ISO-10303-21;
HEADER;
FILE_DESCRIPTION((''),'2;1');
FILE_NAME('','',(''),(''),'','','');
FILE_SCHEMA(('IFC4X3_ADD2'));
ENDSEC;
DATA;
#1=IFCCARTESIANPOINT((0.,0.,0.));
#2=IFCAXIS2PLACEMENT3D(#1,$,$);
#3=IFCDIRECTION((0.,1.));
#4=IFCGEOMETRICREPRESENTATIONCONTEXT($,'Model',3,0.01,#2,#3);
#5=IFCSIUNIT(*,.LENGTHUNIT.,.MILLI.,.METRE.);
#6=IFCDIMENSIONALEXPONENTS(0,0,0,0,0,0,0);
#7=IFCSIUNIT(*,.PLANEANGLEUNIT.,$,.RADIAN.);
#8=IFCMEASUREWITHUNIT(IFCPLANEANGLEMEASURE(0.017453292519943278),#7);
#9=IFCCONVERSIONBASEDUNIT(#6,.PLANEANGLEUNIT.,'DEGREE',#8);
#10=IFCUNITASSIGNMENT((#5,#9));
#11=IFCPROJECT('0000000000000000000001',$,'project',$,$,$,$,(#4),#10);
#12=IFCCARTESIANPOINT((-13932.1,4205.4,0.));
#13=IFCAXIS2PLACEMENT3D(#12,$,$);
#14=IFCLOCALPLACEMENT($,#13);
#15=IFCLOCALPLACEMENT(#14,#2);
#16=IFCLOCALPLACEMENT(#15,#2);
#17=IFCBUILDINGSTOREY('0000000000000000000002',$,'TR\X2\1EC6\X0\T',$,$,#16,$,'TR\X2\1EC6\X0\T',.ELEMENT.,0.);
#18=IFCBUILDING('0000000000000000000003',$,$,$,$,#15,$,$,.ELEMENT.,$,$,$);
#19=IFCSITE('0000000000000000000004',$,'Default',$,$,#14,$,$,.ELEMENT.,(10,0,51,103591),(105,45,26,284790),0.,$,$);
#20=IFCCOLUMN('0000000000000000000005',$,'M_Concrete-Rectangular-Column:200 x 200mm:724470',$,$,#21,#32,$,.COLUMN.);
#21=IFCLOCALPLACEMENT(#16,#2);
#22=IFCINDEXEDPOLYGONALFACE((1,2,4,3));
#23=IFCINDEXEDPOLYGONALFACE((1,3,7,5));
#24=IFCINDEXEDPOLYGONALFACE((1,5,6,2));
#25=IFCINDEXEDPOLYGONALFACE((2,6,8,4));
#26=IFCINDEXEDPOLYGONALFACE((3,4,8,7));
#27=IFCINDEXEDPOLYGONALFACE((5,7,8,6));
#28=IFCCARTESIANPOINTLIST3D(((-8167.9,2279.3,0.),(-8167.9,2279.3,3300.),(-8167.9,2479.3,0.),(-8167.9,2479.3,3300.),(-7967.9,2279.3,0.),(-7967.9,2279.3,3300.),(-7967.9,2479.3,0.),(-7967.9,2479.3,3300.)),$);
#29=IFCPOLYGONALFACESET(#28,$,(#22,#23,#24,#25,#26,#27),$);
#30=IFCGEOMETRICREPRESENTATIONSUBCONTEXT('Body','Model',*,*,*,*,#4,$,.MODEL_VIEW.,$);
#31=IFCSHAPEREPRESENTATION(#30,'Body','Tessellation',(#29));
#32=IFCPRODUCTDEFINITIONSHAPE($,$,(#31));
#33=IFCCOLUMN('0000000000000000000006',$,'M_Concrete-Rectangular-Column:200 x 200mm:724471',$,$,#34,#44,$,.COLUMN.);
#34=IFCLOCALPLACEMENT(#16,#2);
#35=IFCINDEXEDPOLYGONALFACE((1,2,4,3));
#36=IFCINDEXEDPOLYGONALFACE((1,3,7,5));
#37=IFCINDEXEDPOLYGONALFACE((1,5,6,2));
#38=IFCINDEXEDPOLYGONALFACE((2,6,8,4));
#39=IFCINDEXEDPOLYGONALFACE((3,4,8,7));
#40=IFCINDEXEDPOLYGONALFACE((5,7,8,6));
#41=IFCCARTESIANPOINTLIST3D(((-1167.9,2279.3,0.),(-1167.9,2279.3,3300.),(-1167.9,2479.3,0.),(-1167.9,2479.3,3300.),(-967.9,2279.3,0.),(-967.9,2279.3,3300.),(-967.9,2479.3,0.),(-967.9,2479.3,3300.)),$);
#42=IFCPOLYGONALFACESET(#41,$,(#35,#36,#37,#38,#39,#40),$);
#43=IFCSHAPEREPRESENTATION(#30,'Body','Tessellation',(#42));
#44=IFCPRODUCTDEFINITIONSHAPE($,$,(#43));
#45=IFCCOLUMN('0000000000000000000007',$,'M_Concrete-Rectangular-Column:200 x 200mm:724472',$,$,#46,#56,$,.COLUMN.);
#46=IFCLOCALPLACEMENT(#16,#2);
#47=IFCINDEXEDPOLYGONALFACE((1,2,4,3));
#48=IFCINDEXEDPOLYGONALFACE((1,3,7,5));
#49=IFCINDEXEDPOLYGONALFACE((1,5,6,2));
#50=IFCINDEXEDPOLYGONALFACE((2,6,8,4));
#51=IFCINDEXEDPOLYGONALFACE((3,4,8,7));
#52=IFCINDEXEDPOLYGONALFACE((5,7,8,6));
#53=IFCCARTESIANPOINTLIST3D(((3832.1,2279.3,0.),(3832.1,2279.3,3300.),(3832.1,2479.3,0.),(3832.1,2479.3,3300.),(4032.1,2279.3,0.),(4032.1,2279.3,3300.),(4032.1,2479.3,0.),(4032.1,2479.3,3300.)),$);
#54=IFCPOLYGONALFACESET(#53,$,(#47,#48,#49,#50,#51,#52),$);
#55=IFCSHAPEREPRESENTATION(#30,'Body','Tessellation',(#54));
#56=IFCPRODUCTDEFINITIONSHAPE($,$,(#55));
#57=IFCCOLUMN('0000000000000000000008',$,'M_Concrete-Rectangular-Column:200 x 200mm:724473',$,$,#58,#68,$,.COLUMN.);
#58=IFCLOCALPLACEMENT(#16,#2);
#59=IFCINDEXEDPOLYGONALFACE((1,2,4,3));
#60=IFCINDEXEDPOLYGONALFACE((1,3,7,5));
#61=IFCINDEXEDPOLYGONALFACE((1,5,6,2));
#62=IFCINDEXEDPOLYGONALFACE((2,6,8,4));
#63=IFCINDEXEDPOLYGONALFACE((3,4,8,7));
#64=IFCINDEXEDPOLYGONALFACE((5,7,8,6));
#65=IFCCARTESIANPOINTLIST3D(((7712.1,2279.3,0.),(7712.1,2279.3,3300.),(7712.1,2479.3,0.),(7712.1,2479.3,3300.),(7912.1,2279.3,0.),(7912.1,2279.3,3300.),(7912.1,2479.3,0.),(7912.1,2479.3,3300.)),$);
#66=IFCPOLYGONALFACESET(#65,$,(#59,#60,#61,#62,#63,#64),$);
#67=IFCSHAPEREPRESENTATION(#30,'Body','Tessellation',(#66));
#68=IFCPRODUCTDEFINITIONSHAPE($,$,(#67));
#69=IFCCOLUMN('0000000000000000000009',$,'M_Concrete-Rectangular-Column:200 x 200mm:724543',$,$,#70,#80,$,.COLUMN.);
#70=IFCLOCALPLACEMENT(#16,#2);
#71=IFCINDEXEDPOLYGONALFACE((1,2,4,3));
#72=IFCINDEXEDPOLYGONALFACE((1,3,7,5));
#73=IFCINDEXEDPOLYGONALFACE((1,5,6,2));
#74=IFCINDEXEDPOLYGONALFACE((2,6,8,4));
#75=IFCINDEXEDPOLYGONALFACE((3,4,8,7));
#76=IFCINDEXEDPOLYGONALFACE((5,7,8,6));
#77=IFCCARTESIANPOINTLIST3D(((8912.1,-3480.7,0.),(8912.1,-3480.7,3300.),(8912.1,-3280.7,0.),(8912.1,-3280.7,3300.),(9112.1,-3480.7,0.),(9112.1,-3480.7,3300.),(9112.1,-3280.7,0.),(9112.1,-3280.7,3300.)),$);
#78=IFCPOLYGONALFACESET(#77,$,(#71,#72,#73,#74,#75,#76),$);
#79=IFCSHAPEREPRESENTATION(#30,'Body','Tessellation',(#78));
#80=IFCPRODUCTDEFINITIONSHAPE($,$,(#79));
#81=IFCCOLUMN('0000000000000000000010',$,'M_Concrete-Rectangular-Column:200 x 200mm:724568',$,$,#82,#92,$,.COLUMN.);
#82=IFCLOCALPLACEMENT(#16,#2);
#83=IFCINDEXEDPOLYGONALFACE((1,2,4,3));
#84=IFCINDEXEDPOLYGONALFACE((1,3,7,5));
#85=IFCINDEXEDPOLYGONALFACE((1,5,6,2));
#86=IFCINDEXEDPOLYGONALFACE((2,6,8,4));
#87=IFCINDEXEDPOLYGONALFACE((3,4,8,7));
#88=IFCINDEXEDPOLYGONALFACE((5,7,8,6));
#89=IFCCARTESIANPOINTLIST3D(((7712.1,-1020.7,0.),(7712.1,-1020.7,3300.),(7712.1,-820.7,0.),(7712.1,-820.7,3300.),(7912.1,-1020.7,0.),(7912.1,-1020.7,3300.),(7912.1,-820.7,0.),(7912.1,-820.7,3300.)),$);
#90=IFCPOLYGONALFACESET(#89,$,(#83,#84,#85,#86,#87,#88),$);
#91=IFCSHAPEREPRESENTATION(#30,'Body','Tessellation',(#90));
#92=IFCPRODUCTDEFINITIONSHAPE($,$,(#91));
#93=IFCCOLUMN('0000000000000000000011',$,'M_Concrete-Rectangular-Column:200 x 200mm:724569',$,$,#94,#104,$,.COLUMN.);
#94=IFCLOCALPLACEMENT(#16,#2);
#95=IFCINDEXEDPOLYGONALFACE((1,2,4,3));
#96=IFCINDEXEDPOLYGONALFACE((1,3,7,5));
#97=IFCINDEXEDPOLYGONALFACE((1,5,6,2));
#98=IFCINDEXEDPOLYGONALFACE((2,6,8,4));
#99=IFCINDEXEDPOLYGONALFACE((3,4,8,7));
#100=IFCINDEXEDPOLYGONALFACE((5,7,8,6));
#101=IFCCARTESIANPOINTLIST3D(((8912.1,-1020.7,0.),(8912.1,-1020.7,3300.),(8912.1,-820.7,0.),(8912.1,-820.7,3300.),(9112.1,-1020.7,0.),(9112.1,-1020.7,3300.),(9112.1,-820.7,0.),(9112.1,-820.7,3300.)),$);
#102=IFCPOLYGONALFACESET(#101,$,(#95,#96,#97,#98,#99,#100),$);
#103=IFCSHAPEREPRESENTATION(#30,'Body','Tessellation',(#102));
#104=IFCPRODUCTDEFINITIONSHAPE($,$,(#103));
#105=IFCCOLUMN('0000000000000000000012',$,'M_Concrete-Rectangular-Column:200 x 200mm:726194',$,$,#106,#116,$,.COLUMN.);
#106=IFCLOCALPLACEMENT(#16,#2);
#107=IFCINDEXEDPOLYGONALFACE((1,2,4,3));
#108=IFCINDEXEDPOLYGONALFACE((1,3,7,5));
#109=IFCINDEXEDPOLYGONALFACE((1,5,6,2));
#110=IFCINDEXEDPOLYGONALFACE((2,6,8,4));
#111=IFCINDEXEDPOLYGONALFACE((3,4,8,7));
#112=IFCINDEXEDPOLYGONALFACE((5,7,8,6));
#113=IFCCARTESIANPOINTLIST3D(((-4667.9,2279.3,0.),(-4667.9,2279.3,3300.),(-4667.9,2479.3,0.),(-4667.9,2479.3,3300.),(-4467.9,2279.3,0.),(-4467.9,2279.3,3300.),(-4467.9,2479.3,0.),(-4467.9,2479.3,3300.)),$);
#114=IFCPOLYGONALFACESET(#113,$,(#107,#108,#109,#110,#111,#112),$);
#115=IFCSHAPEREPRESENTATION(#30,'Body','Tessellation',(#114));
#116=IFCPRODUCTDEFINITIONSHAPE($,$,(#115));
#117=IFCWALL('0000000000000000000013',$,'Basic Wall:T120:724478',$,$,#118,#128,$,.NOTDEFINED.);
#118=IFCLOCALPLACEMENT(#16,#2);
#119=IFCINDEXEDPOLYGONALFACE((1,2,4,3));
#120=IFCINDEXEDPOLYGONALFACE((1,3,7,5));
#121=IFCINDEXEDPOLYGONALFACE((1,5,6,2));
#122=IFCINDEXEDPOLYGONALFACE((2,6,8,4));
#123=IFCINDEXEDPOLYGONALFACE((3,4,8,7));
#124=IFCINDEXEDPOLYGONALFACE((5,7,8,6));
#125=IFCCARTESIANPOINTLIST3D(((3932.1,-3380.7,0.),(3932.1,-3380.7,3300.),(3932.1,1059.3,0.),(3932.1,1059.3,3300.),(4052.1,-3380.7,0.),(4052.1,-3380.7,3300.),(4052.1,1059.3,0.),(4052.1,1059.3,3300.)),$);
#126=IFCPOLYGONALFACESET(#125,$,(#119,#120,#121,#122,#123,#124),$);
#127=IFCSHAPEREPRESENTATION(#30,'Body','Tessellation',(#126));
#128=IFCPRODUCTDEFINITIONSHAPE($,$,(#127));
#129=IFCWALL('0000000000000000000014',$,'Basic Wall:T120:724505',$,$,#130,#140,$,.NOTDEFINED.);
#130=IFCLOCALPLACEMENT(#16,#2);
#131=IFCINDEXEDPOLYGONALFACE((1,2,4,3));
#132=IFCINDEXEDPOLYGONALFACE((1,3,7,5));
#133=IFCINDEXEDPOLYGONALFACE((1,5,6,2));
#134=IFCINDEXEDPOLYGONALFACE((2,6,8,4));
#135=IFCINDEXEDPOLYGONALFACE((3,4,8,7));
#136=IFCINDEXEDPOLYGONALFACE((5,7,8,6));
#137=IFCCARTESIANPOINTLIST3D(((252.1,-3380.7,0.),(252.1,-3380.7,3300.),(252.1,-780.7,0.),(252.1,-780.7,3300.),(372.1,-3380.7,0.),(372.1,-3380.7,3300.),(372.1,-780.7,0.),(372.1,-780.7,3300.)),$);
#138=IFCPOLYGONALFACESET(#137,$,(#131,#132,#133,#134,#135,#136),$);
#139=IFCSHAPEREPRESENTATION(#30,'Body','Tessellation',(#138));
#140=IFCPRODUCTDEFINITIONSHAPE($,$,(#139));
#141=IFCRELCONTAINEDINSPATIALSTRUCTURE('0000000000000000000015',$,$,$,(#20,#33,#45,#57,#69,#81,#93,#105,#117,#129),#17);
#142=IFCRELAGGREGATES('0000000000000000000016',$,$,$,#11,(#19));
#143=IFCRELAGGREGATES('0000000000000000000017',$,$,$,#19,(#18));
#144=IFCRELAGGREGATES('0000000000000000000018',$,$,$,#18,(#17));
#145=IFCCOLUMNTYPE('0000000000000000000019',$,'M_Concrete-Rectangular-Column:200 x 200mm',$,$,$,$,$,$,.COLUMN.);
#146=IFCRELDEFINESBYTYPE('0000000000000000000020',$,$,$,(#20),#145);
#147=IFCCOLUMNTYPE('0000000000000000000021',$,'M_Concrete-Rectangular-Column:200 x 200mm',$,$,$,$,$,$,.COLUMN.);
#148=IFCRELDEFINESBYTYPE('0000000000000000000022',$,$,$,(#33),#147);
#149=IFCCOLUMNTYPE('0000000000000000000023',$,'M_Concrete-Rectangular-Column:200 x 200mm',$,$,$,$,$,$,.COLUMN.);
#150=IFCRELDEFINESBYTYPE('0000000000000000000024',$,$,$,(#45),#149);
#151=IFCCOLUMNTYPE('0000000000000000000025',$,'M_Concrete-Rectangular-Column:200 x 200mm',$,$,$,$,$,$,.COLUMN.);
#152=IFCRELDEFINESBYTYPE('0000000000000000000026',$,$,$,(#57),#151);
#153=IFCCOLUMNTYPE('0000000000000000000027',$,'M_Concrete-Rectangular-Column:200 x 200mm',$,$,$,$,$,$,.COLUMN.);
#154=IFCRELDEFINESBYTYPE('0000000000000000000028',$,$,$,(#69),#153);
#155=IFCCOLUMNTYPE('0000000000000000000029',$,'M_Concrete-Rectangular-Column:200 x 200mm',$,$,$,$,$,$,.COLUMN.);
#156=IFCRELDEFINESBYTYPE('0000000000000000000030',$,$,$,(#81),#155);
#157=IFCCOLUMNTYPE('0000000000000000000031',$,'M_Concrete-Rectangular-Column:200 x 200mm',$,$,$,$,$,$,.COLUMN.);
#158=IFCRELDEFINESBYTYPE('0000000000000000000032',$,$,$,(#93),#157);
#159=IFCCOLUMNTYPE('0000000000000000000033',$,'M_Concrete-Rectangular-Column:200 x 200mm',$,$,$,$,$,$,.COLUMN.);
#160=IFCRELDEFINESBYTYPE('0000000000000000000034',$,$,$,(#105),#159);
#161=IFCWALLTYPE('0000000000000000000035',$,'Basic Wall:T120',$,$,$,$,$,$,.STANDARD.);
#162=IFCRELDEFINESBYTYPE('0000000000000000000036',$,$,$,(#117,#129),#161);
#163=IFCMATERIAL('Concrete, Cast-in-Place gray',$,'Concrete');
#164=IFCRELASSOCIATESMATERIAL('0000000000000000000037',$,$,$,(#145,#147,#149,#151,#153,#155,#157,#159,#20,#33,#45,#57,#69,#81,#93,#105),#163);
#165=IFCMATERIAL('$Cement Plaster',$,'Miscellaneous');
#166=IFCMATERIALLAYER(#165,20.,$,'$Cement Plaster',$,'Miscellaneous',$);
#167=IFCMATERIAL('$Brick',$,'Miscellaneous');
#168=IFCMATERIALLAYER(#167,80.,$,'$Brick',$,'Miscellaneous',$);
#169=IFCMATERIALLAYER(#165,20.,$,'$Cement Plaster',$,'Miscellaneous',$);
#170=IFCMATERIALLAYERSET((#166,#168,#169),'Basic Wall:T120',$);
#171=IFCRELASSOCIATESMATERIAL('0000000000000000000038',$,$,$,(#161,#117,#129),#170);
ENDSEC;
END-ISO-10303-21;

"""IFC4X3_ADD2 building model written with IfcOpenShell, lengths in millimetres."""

from ifc_helpers import new_model, entity, si_unit, converted_unit, direction, frame, frame_2d, origin, origin_2d_with_axis, place, context, subcontext, project, spatial, rectangle, extrude, source, transform, mapped, material, layer, layer_set, material_profile, profile_set, profile_usage, type_object, type_shapes, element, save


model = new_model("IFC4X3_ADD2")

# Units and contexts
model_context = context("Model", 3, precision=0.01, world=origin(), true_north=direction((0.0, 1.0)))
body_context = subcontext(model_context, "Body", "Model", "MODEL_VIEW")
ifc_project = project(units=[si_unit("LENGTHUNIT", "METRE", prefix="MILLI"), converted_unit("PLANEANGLEUNIT", "DEGREE", entity("IfcPlaneAngleMeasure", 0.017453292519943278), si_unit("PLANEANGLEUNIT", "RADIAN"), dimensions=[0, 0, 0, 0, 0, 0, 0])], contexts=[model_context])

# Site, building, storey
site_placement = place(None, frame((-13932.1, 4205.4, 0.0)))
site = spatial("IfcSite", under=ifc_project, at=site_placement, Name="Default", CompositionType="ELEMENT", RefLatitude=(10, 0, 51, 103591), RefLongitude=(105, 45, 26, 284790), RefElevation=0.0)
building_placement = place(site_placement, origin())
building = spatial("IfcBuilding", under=site, at=building_placement, CompositionType="ELEMENT")
storey_placement = place(building_placement, origin())
storey = spatial("IfcBuildingStorey", under=building, at=storey_placement, Name="TRỆT", LongName="TRỆT", CompositionType="ELEMENT", Elevation=0.0)

# Columns
ifc_material_1 = material(Name="Concrete, Cast-in-Place gray", Category="Concrete")
ifc_material_profile = material_profile(ifc_material_1, rectangle(XDim=200.0, YDim=200.0, at=frame_2d((0.0, 14.3), x_axis=(1.0, 0.0))), Name="200 x 200mm")
ifc_profile_set = profile_set([ifc_material_profile], Name="200 x 200mm")
ifc_profile_usage = profile_usage(ifc_profile_set)
column_type_1 = type_object("IfcColumnType", Name="M_Concrete-Rectangular-Column:200 x 200mm", PredefinedType="COLUMN", material=ifc_profile_set)
shared_shape_1 = source(origin(), body_context, "Body", "SweptSolid", [
    extrude(rectangle(XDim=200.0, YDim=200.0, at=frame_2d((0.0, 0.0), x_axis=(1.0, 0.0))), frame((-8067.9, 2379.3, 0.0), z_axis=(0.0, 0.0, 1.0), x_axis=(-1.0, 0.0, 0.0)), (0.0, 0.0, 1.0), 3300.0),
])
type_shapes(column_type_1, [shared_shape_1])
column_1_placement = place(storey_placement, origin())
element("IfcColumn", 1, at=column_1_placement, inside=storey, type_object=column_type_1, material=ifc_profile_usage, Name="M_Concrete-Rectangular-Column:200 x 200mm:724470", PredefinedType="COLUMN", context=body_context, shape_type="MappedRepresentation", body=[
    mapped(shared_shape_1, transform((0.0, 0.0, 0.0), scale=1.0)),
])
column_type_2 = type_object("IfcColumnType", Name="M_Concrete-Rectangular-Column:200 x 200mm", PredefinedType="COLUMN", material=ifc_profile_set)
shared_shape_2 = source(origin(), body_context, "Body", "SweptSolid", [
    extrude(rectangle(XDim=200.0, YDim=200.0, at=frame_2d((0.0, 0.0), x_axis=(1.0, 0.0))), frame((-1067.9, 2379.3, 0.0), z_axis=(0.0, 0.0, 1.0), x_axis=(-1.0, 0.0, 0.0)), (0.0, 0.0, 1.0), 3300.0),
])
type_shapes(column_type_2, [shared_shape_2])
column_2_placement = place(storey_placement, origin())
element("IfcColumn", 2, at=column_2_placement, inside=storey, type_object=column_type_2, material=ifc_profile_usage, Name="M_Concrete-Rectangular-Column:200 x 200mm:724471", PredefinedType="COLUMN", context=body_context, shape_type="MappedRepresentation", body=[
    mapped(shared_shape_2, transform((0.0, 0.0, 0.0), scale=1.0)),
])
column_type_3 = type_object("IfcColumnType", Name="M_Concrete-Rectangular-Column:200 x 200mm", PredefinedType="COLUMN", material=ifc_profile_set)
shared_shape_3 = source(origin(), body_context, "Body", "SweptSolid", [
    extrude(rectangle(XDim=200.0, YDim=200.0, at=frame_2d((0.0, 0.0), x_axis=(1.0, 0.0))), frame((3932.1, 2379.3, 0.0), z_axis=(0.0, 0.0, 1.0), x_axis=(-1.0, 0.0, 0.0)), (0.0, 0.0, 1.0), 3300.0),
])
type_shapes(column_type_3, [shared_shape_3])
column_3_placement = place(storey_placement, origin())
element("IfcColumn", 3, at=column_3_placement, inside=storey, type_object=column_type_3, material=ifc_profile_usage, Name="M_Concrete-Rectangular-Column:200 x 200mm:724472", PredefinedType="COLUMN", context=body_context, shape_type="MappedRepresentation", body=[
    mapped(shared_shape_3, transform((0.0, 0.0, 0.0), scale=1.0)),
])
column_type_4 = type_object("IfcColumnType", Name="M_Concrete-Rectangular-Column:200 x 200mm", PredefinedType="COLUMN", material=ifc_profile_set)
shared_shape_4 = source(origin(), body_context, "Body", "SweptSolid", [
    extrude(rectangle(XDim=200.0, YDim=200.0, at=frame_2d((0.0, 0.0), x_axis=(1.0, 0.0))), frame((7812.1, 2379.3, 0.0), z_axis=(0.0, 0.0, 1.0), x_axis=(-1.0, 0.0, 0.0)), (0.0, 0.0, 1.0), 3300.0),
])
type_shapes(column_type_4, [shared_shape_4])
column_4_placement = place(storey_placement, origin())
element("IfcColumn", 4, at=column_4_placement, inside=storey, type_object=column_type_4, material=ifc_profile_usage, Name="M_Concrete-Rectangular-Column:200 x 200mm:724473", PredefinedType="COLUMN", context=body_context, shape_type="MappedRepresentation", body=[
    mapped(shared_shape_4, transform((0.0, 0.0, 0.0), scale=1.0)),
])
column_type_5 = type_object("IfcColumnType", Name="M_Concrete-Rectangular-Column:200 x 200mm", PredefinedType="COLUMN", material=ifc_profile_set)
shared_shape_5 = source(origin(), body_context, "Body", "SweptSolid", [
    extrude(rectangle(XDim=200.0, YDim=200.0, at=frame_2d((0.0, 0.0), x_axis=(1.0, 0.0))), frame((9012.1, -3380.7, 0.0), z_axis=(0.0, 0.0, 1.0), x_axis=(0.0, 1.0, 0.0)), (0.0, 0.0, 1.0), 3300.0),
])
type_shapes(column_type_5, [shared_shape_5])
column_5_placement = place(storey_placement, origin())
element("IfcColumn", 5, at=column_5_placement, inside=storey, type_object=column_type_5, material=ifc_profile_usage, Name="M_Concrete-Rectangular-Column:200 x 200mm:724543", PredefinedType="COLUMN", context=body_context, shape_type="MappedRepresentation", body=[
    mapped(shared_shape_5, transform((0.0, 0.0, 0.0), scale=1.0)),
])
column_type_6 = type_object("IfcColumnType", Name="M_Concrete-Rectangular-Column:200 x 200mm", PredefinedType="COLUMN", material=ifc_profile_set)
shared_shape_6 = source(origin(), body_context, "Body", "SweptSolid", [
    extrude(rectangle(XDim=200.0, YDim=200.0, at=frame_2d((0.0, 0.0), x_axis=(1.0, 0.0))), frame((7812.1, -920.7, 0.0), z_axis=(0.0, 0.0, 1.0), x_axis=(0.0, 1.0, 0.0)), (0.0, 0.0, 1.0), 3300.0),
])
type_shapes(column_type_6, [shared_shape_6])
column_6_placement = place(storey_placement, origin())
element("IfcColumn", 6, at=column_6_placement, inside=storey, type_object=column_type_6, material=ifc_profile_usage, Name="M_Concrete-Rectangular-Column:200 x 200mm:724568", PredefinedType="COLUMN", context=body_context, shape_type="MappedRepresentation", body=[
    mapped(shared_shape_6, transform((0.0, 0.0, 0.0), scale=1.0)),
])
column_type_7 = type_object("IfcColumnType", Name="M_Concrete-Rectangular-Column:200 x 200mm", PredefinedType="COLUMN", material=ifc_profile_set)
shared_shape_7 = source(origin(), body_context, "Body", "SweptSolid", [
    extrude(rectangle(XDim=200.0, YDim=200.0, at=frame_2d((0.0, 0.0), x_axis=(1.0, 0.0))), frame((9012.1, -920.7, 0.0), z_axis=(0.0, 0.0, 1.0), x_axis=(0.0, 1.0, 0.0)), (0.0, 0.0, 1.0), 3300.0),
])
type_shapes(column_type_7, [shared_shape_7])
column_7_placement = place(storey_placement, origin())
element("IfcColumn", 7, at=column_7_placement, inside=storey, type_object=column_type_7, material=ifc_profile_usage, Name="M_Concrete-Rectangular-Column:200 x 200mm:724569", PredefinedType="COLUMN", context=body_context, shape_type="MappedRepresentation", body=[
    mapped(shared_shape_7, transform((0.0, 0.0, 0.0), scale=1.0)),
])
column_type_8 = type_object("IfcColumnType", Name="M_Concrete-Rectangular-Column:200 x 200mm", PredefinedType="COLUMN", material=ifc_profile_set)
shared_shape_8 = source(origin(), body_context, "Body", "SweptSolid", [
    extrude(rectangle(XDim=200.0, YDim=200.0, at=origin_2d_with_axis()), frame((-4567.9, 2379.3, 0.0), z_axis=(0.0, 0.0, 1.0), x_axis=(-1.0, 0.0, 0.0)), (0.0, 0.0, 1.0), 3300.0),
])
type_shapes(column_type_8, [shared_shape_8])
column_8_placement = place(storey_placement, origin())
element("IfcColumn", 8, at=column_8_placement, inside=storey, type_object=column_type_8, material=ifc_profile_usage, Name="M_Concrete-Rectangular-Column:200 x 200mm:726194", PredefinedType="COLUMN", context=body_context, shape_type="MappedRepresentation", body=[
    mapped(shared_shape_8, transform((0.0, 0.0, 0.0), scale=1.0)),
])

# Walls
ifc_material_2 = material(Name="$Cement Plaster", Category="Miscellaneous")
ifc_layer_1 = layer(ifc_material_2, 20.0, Name="$Cement Plaster", Category="Miscellaneous")
ifc_material_3 = material(Name="$Brick", Category="Miscellaneous")
ifc_layer_2 = layer(ifc_material_3, 80.0, Name="$Brick", Category="Miscellaneous")
ifc_layer_3 = layer(ifc_material_2, 20.0, Name="$Cement Plaster", Category="Miscellaneous")
ifc_layer_set_1 = layer_set([ifc_layer_1, ifc_layer_2, ifc_layer_3], Name="Basic Wall:T120")
wall_type_1 = type_object("IfcWallType", Name="Basic Wall:T120", PredefinedType="STANDARD", material=ifc_layer_set_1)
wall_1_placement = place(storey_placement, frame((3992.1, 1059.3, 0.0), z_axis=(0.0, 0.0, 1.0), x_axis=(0.0, -1.0, 0.0)))
element("IfcWall", 9, at=wall_1_placement, inside=storey, type_object=wall_type_1, material=ifc_layer_set_1, Name="Basic Wall:T120:724478", PredefinedType="NOTDEFINED", context=body_context, shape_type="SweptSolid", body=[
    extrude(rectangle(XDim=4440.0, YDim=120.0, at=frame_2d((2220.0, 0.0), x_axis=(-1.0, 0.0))), origin(), (0.0, 0.0, 1.0), 3300.0),
])
wall_2_placement = place(storey_placement, frame((312.1, -780.7, 0.0), z_axis=(0.0, 0.0, 1.0), x_axis=(0.0, -1.0, 0.0)))
element("IfcWall", 10, at=wall_2_placement, inside=storey, type_object=wall_type_1, material=ifc_layer_set_1, Name="Basic Wall:T120:724505", PredefinedType="NOTDEFINED", context=body_context, shape_type="SweptSolid", body=[
    extrude(rectangle(XDim=2600.0, YDim=120.0, at=frame_2d((1300.0, 0.0), x_axis=(-1.0, 0.0))), origin(), (0.0, 0.0, 1.0), 3300.0),
])

save(model, "model.ifc")
